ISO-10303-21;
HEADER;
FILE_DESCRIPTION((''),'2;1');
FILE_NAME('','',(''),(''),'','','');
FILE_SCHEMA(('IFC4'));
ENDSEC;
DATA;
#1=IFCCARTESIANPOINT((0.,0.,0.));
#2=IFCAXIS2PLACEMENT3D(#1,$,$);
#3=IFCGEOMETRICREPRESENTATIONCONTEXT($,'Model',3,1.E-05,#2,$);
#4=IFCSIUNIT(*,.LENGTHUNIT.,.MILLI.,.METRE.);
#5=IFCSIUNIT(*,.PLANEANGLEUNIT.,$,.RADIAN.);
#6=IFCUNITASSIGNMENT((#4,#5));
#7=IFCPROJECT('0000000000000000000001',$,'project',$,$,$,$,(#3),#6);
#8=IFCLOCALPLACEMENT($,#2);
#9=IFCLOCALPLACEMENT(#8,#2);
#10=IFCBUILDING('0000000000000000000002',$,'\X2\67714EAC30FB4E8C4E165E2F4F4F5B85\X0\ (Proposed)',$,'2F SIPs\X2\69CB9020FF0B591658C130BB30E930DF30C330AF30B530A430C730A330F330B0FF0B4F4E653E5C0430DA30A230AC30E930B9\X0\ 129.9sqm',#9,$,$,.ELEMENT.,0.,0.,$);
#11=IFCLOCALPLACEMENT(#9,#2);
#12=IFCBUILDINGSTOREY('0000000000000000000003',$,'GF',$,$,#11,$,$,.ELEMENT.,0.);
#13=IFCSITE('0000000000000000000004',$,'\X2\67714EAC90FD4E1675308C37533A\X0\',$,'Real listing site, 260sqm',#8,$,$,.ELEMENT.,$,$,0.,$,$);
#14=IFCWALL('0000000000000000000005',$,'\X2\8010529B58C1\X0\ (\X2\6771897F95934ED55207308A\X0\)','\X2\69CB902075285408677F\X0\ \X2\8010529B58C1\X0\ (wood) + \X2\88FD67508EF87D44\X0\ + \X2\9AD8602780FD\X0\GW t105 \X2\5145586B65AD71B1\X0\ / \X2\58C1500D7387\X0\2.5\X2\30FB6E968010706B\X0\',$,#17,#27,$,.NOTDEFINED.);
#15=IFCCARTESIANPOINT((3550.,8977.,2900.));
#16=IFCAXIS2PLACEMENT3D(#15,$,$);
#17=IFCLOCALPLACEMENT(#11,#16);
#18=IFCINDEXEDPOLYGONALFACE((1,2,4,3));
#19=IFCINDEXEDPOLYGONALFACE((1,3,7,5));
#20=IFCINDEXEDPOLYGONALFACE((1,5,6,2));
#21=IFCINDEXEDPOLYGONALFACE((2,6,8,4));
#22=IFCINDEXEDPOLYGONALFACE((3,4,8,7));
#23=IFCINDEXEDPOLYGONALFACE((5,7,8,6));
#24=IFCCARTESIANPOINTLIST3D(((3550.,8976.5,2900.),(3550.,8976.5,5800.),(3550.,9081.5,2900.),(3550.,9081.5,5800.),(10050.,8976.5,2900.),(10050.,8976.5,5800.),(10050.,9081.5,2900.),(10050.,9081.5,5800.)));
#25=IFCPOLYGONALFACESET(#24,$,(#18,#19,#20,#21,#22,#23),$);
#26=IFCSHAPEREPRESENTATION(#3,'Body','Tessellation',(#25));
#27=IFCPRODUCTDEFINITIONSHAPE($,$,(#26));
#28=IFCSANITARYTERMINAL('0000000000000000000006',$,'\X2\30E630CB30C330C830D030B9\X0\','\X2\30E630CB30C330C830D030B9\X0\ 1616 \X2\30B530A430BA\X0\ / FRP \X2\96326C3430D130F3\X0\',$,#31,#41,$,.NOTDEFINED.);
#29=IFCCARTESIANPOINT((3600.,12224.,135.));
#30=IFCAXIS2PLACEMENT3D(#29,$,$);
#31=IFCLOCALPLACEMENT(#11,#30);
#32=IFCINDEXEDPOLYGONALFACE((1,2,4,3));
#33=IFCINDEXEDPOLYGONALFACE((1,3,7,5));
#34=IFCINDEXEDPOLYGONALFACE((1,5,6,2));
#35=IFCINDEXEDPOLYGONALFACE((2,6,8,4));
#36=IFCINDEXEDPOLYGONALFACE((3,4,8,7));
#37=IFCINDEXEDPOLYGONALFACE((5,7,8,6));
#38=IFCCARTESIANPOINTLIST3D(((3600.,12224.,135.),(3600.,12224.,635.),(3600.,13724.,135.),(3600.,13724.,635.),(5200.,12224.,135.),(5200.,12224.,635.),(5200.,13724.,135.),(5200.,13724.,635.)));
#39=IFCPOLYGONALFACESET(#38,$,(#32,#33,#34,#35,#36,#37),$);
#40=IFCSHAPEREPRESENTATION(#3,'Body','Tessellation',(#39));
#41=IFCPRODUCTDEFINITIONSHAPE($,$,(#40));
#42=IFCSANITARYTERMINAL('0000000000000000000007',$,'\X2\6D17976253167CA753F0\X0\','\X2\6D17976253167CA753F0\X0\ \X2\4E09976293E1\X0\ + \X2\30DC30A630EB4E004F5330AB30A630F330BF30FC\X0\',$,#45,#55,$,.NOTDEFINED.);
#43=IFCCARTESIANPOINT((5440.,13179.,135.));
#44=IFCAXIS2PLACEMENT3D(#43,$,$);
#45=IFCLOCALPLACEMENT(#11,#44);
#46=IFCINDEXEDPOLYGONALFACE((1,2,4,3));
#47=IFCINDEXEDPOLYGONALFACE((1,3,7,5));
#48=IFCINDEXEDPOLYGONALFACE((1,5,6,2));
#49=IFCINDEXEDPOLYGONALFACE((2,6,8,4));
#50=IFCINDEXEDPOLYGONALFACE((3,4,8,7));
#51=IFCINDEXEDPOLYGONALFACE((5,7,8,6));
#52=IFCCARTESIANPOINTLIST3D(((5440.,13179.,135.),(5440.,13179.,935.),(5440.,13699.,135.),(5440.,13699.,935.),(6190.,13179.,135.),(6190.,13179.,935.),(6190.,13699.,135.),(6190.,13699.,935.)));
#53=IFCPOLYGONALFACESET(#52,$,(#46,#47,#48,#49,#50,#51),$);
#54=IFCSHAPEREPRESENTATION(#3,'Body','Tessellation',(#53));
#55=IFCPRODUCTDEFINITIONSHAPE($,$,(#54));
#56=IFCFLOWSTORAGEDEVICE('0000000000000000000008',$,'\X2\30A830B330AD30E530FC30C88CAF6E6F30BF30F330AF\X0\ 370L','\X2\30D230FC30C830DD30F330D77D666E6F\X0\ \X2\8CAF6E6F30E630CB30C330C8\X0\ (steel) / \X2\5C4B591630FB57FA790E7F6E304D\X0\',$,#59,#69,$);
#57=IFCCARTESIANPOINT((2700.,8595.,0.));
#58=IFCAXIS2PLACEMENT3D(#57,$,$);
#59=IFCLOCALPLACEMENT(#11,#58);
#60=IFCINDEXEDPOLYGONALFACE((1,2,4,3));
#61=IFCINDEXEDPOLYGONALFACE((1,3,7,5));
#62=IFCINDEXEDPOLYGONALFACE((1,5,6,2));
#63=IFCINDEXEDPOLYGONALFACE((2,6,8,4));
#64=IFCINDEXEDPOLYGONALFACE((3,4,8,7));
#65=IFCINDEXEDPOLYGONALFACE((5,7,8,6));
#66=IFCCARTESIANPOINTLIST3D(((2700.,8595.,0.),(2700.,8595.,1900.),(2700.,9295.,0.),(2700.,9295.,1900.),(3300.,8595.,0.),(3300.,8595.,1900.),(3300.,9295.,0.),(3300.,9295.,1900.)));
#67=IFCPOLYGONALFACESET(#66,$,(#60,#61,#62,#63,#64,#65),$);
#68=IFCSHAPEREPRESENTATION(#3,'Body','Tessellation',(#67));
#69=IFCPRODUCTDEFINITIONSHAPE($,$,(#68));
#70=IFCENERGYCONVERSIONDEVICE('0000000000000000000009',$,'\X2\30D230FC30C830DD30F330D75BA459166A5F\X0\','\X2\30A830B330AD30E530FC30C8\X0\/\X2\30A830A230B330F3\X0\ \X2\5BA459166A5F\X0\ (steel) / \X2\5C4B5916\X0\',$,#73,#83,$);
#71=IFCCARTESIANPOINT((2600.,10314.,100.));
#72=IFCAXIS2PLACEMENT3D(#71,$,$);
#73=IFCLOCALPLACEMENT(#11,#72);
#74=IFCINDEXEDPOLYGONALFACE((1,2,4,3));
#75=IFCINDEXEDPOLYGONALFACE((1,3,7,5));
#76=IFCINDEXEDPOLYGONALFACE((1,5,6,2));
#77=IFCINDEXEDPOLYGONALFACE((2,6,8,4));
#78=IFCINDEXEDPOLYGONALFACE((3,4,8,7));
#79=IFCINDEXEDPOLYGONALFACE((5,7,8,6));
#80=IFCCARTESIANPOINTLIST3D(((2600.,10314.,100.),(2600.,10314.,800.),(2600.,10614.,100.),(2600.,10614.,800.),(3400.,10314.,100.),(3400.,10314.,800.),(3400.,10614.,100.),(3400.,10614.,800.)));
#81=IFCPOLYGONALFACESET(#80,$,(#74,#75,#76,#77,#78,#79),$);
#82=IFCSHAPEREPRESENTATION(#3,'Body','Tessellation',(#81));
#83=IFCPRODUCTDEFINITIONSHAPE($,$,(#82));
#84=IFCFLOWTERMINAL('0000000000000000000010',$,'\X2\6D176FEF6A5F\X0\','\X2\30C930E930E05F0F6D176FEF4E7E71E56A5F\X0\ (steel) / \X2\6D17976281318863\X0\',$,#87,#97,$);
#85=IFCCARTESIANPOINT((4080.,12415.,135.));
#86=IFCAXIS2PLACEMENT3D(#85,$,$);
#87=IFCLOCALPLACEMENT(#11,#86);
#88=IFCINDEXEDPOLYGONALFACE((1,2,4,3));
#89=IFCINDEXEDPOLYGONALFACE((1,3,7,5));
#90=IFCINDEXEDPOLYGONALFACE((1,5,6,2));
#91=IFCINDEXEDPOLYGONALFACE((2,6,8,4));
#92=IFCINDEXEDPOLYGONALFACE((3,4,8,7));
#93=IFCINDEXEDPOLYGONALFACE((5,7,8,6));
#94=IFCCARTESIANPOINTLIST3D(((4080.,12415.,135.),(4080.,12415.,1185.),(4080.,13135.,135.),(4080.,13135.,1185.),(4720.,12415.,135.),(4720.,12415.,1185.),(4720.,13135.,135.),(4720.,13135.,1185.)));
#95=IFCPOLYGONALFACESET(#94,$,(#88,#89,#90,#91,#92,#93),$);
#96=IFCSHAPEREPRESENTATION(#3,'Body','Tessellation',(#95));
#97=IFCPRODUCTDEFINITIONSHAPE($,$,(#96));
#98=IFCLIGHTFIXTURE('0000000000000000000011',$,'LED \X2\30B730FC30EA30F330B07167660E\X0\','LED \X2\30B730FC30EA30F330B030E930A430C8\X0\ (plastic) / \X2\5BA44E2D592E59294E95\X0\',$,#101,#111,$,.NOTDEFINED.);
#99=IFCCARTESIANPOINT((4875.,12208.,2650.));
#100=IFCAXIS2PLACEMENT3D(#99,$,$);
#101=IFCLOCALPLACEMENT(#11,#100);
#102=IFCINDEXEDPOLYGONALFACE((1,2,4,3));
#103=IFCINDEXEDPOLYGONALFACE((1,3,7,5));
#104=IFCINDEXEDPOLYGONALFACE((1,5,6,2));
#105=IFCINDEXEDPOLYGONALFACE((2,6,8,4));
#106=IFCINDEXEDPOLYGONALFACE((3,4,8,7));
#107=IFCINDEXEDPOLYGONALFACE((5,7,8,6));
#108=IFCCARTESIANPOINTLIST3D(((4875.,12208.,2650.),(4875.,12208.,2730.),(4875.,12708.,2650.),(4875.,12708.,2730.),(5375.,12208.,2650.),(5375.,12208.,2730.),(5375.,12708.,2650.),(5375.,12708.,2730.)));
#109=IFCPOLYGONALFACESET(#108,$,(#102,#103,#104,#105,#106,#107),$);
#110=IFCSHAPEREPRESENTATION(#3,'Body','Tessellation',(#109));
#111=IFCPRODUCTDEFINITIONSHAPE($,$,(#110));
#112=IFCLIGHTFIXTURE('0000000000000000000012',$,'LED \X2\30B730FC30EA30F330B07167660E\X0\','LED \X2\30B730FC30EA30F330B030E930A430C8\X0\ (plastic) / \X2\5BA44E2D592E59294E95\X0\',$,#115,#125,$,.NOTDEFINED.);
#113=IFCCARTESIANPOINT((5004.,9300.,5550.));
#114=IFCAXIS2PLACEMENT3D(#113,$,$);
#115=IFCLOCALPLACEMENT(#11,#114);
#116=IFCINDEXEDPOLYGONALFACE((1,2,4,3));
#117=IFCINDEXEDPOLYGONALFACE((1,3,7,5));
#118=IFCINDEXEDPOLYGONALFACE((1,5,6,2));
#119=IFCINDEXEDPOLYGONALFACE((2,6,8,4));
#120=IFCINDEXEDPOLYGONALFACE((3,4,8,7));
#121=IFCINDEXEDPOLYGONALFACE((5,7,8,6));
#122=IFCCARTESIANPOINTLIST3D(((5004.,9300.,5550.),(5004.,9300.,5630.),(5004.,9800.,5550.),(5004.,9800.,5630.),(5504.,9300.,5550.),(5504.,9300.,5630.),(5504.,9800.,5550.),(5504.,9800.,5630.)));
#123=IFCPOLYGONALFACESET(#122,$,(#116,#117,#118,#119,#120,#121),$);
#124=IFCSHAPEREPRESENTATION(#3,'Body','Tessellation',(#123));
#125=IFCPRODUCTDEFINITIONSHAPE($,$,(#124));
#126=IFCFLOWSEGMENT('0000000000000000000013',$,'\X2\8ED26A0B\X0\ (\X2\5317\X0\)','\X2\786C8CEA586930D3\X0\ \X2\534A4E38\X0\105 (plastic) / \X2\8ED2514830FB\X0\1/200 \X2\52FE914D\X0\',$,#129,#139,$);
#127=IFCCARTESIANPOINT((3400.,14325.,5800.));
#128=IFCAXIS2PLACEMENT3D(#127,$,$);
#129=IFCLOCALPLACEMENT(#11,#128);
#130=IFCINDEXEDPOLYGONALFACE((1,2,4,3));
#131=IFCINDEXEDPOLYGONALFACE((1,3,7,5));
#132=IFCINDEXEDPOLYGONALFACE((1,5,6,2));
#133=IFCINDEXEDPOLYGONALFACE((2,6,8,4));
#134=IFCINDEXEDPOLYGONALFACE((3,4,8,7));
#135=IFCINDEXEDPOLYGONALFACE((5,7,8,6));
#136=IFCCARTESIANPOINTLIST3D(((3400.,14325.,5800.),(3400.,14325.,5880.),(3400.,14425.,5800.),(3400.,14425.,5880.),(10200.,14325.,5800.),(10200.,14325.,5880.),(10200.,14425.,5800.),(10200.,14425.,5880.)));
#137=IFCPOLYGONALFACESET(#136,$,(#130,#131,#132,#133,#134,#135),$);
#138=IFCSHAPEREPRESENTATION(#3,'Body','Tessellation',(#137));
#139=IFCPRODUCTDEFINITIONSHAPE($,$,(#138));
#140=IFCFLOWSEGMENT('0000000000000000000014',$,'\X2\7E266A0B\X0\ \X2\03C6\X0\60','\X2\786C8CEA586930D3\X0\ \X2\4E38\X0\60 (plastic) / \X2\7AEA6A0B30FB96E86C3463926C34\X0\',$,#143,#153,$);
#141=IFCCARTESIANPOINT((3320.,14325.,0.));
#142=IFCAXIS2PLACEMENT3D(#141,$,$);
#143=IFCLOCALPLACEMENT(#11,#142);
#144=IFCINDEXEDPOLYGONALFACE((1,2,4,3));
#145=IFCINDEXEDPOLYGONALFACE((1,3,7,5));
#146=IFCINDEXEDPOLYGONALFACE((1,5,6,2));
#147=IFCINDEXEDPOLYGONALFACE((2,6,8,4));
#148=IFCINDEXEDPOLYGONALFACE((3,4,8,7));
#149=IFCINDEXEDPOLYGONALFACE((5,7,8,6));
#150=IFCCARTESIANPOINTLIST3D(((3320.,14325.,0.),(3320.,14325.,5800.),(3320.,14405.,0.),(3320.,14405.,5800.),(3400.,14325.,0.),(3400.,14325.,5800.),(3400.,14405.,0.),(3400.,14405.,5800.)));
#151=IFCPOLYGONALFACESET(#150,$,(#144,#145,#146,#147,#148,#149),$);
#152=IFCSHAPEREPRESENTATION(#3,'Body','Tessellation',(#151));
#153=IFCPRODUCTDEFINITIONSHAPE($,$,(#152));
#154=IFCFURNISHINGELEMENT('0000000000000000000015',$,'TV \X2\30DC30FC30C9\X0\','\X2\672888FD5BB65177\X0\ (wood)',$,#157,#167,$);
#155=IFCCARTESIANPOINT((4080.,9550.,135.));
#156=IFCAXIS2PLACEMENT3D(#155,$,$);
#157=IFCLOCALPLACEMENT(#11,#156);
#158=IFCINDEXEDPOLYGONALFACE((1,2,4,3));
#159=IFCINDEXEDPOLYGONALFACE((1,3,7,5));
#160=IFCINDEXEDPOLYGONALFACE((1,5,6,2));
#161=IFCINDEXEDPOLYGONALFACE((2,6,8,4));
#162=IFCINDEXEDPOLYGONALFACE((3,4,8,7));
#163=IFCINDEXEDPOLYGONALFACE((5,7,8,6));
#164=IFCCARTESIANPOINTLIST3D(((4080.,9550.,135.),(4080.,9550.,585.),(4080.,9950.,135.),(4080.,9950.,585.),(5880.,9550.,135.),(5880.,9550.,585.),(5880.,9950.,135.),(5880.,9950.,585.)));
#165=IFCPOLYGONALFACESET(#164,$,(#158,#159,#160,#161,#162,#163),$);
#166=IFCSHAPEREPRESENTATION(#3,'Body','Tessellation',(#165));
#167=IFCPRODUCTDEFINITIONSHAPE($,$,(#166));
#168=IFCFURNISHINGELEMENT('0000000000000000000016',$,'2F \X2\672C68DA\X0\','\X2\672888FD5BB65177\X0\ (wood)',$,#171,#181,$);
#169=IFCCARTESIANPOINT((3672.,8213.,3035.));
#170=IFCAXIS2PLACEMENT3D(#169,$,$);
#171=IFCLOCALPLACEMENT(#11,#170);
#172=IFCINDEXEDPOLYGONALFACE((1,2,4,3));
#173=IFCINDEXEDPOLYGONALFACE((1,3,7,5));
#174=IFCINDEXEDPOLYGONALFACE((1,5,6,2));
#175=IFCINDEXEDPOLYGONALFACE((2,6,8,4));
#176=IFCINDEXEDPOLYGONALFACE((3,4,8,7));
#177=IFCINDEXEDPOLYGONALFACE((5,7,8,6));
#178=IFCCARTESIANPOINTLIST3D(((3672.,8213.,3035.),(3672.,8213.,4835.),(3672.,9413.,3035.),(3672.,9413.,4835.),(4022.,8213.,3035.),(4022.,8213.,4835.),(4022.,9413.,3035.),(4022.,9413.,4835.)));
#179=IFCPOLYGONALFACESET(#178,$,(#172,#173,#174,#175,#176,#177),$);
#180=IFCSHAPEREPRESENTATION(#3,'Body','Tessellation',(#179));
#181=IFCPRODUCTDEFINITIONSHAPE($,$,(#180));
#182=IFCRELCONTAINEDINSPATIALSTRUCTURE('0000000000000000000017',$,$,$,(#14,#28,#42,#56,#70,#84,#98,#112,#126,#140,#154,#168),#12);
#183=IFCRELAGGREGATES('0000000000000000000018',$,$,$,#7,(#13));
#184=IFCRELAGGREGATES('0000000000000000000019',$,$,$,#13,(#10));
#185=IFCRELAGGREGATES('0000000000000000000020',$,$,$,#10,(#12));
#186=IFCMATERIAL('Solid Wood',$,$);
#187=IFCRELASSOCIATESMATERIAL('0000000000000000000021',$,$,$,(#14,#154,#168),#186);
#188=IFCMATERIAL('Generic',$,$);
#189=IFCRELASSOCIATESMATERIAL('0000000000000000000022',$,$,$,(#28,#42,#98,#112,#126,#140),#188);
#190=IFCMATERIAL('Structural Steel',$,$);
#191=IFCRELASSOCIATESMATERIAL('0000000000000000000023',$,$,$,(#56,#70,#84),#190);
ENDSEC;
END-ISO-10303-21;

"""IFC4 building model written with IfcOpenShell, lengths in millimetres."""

from ifc_helpers import new_model, si_unit, frame, frame_2d, origin, place, context, project, spatial, rectangle, extrude, material, element, save


model = new_model("IFC4")

# Units and contexts
model_context = context("Model", 3, precision=1e-05, world=origin())
ifc_project = project(units=[si_unit("LENGTHUNIT", "METRE", prefix="MILLI"), si_unit("PLANEANGLEUNIT", "RADIAN")], contexts=[model_context])

# Site, building, storey
site_placement = place(None, origin())
site = spatial("IfcSite", under=ifc_project, at=site_placement, Name="東京都世田谷区", ObjectType="Real listing site, 260sqm", CompositionType="ELEMENT", RefElevation=0.0)
building_placement = place(site_placement, origin())
building = spatial("IfcBuilding", under=site, at=building_placement, Name="東京・二世帯住宅 (Proposed)", ObjectType="2F SIPs構造＋外壁セラミックサイディング＋低放射ペアガラス 129.9sqm", CompositionType="ELEMENT", ElevationOfRefHeight=0.0, ElevationOfTerrain=0.0)
storey_placement = place(building_placement, origin())
storey = spatial("IfcBuildingStorey", under=building, at=storey_placement, Name="GF", CompositionType="ELEMENT", Elevation=0.0)

# Shared definitions
ifc_material_1 = material(Name="Solid Wood")

# Wall
wall_1_placement = place(storey_placement, frame((3550.0, 8977.0, 2900.0)))
element("IfcWall", 1, at=wall_1_placement, inside=storey, material=ifc_material_1, Name="耐力壁 (東西間仕切り)", Description="構造用合板 耐力壁 (wood) + 製材軸組 + 高性能GW t105 充填断熱 / 壁倍率2.5・準耐火", PredefinedType="NOTDEFINED", context=model_context, shape_type="SweptSolid", body=[
    extrude(rectangle(XDim=6500.0, YDim=105.0, at=frame_2d((3250.0, 52.0))), frame((3550.0, 8977.0, 2900.0)), (0.0, 0.0, 1.0), 2900.0),
])

# Sanitary terminals
ifc_material_2 = material(Name="Generic")
sanitary_terminal_1_placement = place(storey_placement, frame((3600.0, 12224.0, 135.0)))
element("IfcSanitaryTerminal", 2, at=sanitary_terminal_1_placement, inside=storey, material=ifc_material_2, Name="ユニットバス", Description="ユニットバス 1616 サイズ / FRP 防水パン", PredefinedType="NOTDEFINED", context=model_context, shape_type="SweptSolid", body=[
    extrude(rectangle(XDim=1600.0, YDim=1500.0, at=frame_2d((800.0, 750.0))), frame((3600.0, 12224.0, 135.0)), (0.0, 0.0, 1.0), 500.0),
])
sanitary_terminal_2_placement = place(storey_placement, frame((5440.0, 13179.0, 135.0)))
element("IfcSanitaryTerminal", 3, at=sanitary_terminal_2_placement, inside=storey, material=ifc_material_2, Name="洗面化粧台", Description="洗面化粧台 三面鏡 + ボウル一体カウンター", PredefinedType="NOTDEFINED", context=model_context, shape_type="SweptSolid", body=[
    extrude(rectangle(XDim=750.0, YDim=520.0, at=frame_2d((375.0, 260.0))), frame((5440.0, 13179.0, 135.0)), (0.0, 0.0, 1.0), 800.0),
])

# Flow storage device
ifc_material_3 = material(Name="Structural Steel")
flow_storage_device_placement = place(storey_placement, frame((2700.0, 8595.0, 0.0)))
element("IfcFlowStorageDevice", 4, at=flow_storage_device_placement, inside=storey, material=ifc_material_3, Name="エコキュート貯湯タンク 370L", Description="ヒートポンプ給湯 貯湯ユニット (steel) / 屋外・基礎置き", context=model_context, shape_type="SweptSolid", body=[
    extrude(rectangle(XDim=600.0, YDim=700.0, at=frame_2d((300.0, 350.0))), frame((2700.0, 8595.0, 0.0)), (0.0, 0.0, 1.0), 1900.0),
])

# Energy conversion device
energy_conversion_device_placement = place(storey_placement, frame((2600.0, 10314.0, 100.0)))
element("IfcEnergyConversionDevice", 5, at=energy_conversion_device_placement, inside=storey, material=ifc_material_3, Name="ヒートポンプ室外機", Description="エコキュート/エアコン 室外機 (steel) / 屋外", context=model_context, shape_type="SweptSolid", body=[
    extrude(rectangle(XDim=800.0, YDim=300.0, at=frame_2d((400.0, 150.0))), frame((2600.0, 10314.0, 100.0)), (0.0, 0.0, 1.0), 700.0),
])

# Flow terminal
flow_terminal_placement = place(storey_placement, frame((4080.0, 12415.0, 135.0)))
element("IfcFlowTerminal", 6, at=flow_terminal_placement, inside=storey, material=ifc_material_3, Name="洗濯機", Description="ドラム式洗濯乾燥機 (steel) / 洗面脱衣", context=model_context, shape_type="SweptSolid", body=[
    extrude(rectangle(XDim=640.0, YDim=720.0, at=frame_2d((320.0, 360.0))), frame((4080.0, 12415.0, 135.0)), (0.0, 0.0, 1.0), 1050.0),
])

# Light fixtures
light_fixture_1_placement = place(storey_placement, frame((4875.0, 12208.0, 2650.0)))
element("IfcLightFixture", 7, at=light_fixture_1_placement, inside=storey, material=ifc_material_2, Name="LED シーリング照明", Description="LED シーリングライト (plastic) / 室中央天井", PredefinedType="NOTDEFINED", context=model_context, shape_type="SweptSolid", body=[
    extrude(rectangle(XDim=500.0, YDim=500.0, at=frame_2d((250.0, 250.0))), frame((4875.0, 12208.0, 2650.0)), (0.0, 0.0, 1.0), 80.0),
])
light_fixture_2_placement = place(storey_placement, frame((5004.0, 9300.0, 5550.0)))
element("IfcLightFixture", 8, at=light_fixture_2_placement, inside=storey, material=ifc_material_2, Name="LED シーリング照明", Description="LED シーリングライト (plastic) / 室中央天井", PredefinedType="NOTDEFINED", context=model_context, shape_type="SweptSolid", body=[
    extrude(rectangle(XDim=500.0, YDim=500.0, at=frame_2d((250.0, 250.0))), frame((5004.0, 9300.0, 5550.0)), (0.0, 0.0, 1.0), 80.0),
])

# Flow segments
flow_segment_1_placement = place(storey_placement, frame((3400.0, 14325.0, 5800.0)))
element("IfcFlowSegment", 9, at=flow_segment_1_placement, inside=storey, material=ifc_material_2, Name="軒樋 (北)", Description="硬質塩ビ 半丸105 (plastic) / 軒先・1/200 勾配", context=model_context, shape_type="SweptSolid", body=[
    extrude(rectangle(XDim=6800.0, YDim=100.0, at=frame_2d((3400.0, 50.0))), frame((3400.0, 14325.0, 5800.0)), (0.0, 0.0, 1.0), 80.0),
])
flow_segment_2_placement = place(storey_placement, frame((3320.0, 14325.0, 0.0)))
element("IfcFlowSegment", 10, at=flow_segment_2_placement, inside=storey, material=ifc_material_2, Name="縦樋 φ60", Description="硬質塩ビ 丸60 (plastic) / 竪樋・雨水排水", context=model_context, shape_type="SweptSolid", body=[
    extrude(rectangle(XDim=80.0, YDim=80.0, at=frame_2d((40.0, 40.0))), frame((3320.0, 14325.0, 0.0)), (0.0, 0.0, 1.0), 5800.0),
])

# Furnishing elements
furnishing_1_placement = place(storey_placement, frame((4080.0, 9550.0, 135.0)))
element("IfcFurnishingElement", 11, at=furnishing_1_placement, inside=storey, material=ifc_material_1, Name="TV ボード", Description="木製家具 (wood)", context=model_context, shape_type="SweptSolid", body=[
    extrude(rectangle(XDim=1800.0, YDim=400.0, at=frame_2d((900.0, 200.0))), frame((4080.0, 9550.0, 135.0)), (0.0, 0.0, 1.0), 450.0),
])
furnishing_2_placement = place(storey_placement, frame((3672.0, 8213.0, 3035.0)))
element("IfcFurnishingElement", 12, at=furnishing_2_placement, inside=storey, material=ifc_material_1, Name="2F 本棚", Description="木製家具 (wood)", context=model_context, shape_type="SweptSolid", body=[
    extrude(rectangle(XDim=350.0, YDim=1200.0, at=frame_2d((175.0, 600.0))), frame((3672.0, 8213.0, 3035.0)), (0.0, 0.0, 1.0), 1800.0),
])

save(model, "model.ifc")
